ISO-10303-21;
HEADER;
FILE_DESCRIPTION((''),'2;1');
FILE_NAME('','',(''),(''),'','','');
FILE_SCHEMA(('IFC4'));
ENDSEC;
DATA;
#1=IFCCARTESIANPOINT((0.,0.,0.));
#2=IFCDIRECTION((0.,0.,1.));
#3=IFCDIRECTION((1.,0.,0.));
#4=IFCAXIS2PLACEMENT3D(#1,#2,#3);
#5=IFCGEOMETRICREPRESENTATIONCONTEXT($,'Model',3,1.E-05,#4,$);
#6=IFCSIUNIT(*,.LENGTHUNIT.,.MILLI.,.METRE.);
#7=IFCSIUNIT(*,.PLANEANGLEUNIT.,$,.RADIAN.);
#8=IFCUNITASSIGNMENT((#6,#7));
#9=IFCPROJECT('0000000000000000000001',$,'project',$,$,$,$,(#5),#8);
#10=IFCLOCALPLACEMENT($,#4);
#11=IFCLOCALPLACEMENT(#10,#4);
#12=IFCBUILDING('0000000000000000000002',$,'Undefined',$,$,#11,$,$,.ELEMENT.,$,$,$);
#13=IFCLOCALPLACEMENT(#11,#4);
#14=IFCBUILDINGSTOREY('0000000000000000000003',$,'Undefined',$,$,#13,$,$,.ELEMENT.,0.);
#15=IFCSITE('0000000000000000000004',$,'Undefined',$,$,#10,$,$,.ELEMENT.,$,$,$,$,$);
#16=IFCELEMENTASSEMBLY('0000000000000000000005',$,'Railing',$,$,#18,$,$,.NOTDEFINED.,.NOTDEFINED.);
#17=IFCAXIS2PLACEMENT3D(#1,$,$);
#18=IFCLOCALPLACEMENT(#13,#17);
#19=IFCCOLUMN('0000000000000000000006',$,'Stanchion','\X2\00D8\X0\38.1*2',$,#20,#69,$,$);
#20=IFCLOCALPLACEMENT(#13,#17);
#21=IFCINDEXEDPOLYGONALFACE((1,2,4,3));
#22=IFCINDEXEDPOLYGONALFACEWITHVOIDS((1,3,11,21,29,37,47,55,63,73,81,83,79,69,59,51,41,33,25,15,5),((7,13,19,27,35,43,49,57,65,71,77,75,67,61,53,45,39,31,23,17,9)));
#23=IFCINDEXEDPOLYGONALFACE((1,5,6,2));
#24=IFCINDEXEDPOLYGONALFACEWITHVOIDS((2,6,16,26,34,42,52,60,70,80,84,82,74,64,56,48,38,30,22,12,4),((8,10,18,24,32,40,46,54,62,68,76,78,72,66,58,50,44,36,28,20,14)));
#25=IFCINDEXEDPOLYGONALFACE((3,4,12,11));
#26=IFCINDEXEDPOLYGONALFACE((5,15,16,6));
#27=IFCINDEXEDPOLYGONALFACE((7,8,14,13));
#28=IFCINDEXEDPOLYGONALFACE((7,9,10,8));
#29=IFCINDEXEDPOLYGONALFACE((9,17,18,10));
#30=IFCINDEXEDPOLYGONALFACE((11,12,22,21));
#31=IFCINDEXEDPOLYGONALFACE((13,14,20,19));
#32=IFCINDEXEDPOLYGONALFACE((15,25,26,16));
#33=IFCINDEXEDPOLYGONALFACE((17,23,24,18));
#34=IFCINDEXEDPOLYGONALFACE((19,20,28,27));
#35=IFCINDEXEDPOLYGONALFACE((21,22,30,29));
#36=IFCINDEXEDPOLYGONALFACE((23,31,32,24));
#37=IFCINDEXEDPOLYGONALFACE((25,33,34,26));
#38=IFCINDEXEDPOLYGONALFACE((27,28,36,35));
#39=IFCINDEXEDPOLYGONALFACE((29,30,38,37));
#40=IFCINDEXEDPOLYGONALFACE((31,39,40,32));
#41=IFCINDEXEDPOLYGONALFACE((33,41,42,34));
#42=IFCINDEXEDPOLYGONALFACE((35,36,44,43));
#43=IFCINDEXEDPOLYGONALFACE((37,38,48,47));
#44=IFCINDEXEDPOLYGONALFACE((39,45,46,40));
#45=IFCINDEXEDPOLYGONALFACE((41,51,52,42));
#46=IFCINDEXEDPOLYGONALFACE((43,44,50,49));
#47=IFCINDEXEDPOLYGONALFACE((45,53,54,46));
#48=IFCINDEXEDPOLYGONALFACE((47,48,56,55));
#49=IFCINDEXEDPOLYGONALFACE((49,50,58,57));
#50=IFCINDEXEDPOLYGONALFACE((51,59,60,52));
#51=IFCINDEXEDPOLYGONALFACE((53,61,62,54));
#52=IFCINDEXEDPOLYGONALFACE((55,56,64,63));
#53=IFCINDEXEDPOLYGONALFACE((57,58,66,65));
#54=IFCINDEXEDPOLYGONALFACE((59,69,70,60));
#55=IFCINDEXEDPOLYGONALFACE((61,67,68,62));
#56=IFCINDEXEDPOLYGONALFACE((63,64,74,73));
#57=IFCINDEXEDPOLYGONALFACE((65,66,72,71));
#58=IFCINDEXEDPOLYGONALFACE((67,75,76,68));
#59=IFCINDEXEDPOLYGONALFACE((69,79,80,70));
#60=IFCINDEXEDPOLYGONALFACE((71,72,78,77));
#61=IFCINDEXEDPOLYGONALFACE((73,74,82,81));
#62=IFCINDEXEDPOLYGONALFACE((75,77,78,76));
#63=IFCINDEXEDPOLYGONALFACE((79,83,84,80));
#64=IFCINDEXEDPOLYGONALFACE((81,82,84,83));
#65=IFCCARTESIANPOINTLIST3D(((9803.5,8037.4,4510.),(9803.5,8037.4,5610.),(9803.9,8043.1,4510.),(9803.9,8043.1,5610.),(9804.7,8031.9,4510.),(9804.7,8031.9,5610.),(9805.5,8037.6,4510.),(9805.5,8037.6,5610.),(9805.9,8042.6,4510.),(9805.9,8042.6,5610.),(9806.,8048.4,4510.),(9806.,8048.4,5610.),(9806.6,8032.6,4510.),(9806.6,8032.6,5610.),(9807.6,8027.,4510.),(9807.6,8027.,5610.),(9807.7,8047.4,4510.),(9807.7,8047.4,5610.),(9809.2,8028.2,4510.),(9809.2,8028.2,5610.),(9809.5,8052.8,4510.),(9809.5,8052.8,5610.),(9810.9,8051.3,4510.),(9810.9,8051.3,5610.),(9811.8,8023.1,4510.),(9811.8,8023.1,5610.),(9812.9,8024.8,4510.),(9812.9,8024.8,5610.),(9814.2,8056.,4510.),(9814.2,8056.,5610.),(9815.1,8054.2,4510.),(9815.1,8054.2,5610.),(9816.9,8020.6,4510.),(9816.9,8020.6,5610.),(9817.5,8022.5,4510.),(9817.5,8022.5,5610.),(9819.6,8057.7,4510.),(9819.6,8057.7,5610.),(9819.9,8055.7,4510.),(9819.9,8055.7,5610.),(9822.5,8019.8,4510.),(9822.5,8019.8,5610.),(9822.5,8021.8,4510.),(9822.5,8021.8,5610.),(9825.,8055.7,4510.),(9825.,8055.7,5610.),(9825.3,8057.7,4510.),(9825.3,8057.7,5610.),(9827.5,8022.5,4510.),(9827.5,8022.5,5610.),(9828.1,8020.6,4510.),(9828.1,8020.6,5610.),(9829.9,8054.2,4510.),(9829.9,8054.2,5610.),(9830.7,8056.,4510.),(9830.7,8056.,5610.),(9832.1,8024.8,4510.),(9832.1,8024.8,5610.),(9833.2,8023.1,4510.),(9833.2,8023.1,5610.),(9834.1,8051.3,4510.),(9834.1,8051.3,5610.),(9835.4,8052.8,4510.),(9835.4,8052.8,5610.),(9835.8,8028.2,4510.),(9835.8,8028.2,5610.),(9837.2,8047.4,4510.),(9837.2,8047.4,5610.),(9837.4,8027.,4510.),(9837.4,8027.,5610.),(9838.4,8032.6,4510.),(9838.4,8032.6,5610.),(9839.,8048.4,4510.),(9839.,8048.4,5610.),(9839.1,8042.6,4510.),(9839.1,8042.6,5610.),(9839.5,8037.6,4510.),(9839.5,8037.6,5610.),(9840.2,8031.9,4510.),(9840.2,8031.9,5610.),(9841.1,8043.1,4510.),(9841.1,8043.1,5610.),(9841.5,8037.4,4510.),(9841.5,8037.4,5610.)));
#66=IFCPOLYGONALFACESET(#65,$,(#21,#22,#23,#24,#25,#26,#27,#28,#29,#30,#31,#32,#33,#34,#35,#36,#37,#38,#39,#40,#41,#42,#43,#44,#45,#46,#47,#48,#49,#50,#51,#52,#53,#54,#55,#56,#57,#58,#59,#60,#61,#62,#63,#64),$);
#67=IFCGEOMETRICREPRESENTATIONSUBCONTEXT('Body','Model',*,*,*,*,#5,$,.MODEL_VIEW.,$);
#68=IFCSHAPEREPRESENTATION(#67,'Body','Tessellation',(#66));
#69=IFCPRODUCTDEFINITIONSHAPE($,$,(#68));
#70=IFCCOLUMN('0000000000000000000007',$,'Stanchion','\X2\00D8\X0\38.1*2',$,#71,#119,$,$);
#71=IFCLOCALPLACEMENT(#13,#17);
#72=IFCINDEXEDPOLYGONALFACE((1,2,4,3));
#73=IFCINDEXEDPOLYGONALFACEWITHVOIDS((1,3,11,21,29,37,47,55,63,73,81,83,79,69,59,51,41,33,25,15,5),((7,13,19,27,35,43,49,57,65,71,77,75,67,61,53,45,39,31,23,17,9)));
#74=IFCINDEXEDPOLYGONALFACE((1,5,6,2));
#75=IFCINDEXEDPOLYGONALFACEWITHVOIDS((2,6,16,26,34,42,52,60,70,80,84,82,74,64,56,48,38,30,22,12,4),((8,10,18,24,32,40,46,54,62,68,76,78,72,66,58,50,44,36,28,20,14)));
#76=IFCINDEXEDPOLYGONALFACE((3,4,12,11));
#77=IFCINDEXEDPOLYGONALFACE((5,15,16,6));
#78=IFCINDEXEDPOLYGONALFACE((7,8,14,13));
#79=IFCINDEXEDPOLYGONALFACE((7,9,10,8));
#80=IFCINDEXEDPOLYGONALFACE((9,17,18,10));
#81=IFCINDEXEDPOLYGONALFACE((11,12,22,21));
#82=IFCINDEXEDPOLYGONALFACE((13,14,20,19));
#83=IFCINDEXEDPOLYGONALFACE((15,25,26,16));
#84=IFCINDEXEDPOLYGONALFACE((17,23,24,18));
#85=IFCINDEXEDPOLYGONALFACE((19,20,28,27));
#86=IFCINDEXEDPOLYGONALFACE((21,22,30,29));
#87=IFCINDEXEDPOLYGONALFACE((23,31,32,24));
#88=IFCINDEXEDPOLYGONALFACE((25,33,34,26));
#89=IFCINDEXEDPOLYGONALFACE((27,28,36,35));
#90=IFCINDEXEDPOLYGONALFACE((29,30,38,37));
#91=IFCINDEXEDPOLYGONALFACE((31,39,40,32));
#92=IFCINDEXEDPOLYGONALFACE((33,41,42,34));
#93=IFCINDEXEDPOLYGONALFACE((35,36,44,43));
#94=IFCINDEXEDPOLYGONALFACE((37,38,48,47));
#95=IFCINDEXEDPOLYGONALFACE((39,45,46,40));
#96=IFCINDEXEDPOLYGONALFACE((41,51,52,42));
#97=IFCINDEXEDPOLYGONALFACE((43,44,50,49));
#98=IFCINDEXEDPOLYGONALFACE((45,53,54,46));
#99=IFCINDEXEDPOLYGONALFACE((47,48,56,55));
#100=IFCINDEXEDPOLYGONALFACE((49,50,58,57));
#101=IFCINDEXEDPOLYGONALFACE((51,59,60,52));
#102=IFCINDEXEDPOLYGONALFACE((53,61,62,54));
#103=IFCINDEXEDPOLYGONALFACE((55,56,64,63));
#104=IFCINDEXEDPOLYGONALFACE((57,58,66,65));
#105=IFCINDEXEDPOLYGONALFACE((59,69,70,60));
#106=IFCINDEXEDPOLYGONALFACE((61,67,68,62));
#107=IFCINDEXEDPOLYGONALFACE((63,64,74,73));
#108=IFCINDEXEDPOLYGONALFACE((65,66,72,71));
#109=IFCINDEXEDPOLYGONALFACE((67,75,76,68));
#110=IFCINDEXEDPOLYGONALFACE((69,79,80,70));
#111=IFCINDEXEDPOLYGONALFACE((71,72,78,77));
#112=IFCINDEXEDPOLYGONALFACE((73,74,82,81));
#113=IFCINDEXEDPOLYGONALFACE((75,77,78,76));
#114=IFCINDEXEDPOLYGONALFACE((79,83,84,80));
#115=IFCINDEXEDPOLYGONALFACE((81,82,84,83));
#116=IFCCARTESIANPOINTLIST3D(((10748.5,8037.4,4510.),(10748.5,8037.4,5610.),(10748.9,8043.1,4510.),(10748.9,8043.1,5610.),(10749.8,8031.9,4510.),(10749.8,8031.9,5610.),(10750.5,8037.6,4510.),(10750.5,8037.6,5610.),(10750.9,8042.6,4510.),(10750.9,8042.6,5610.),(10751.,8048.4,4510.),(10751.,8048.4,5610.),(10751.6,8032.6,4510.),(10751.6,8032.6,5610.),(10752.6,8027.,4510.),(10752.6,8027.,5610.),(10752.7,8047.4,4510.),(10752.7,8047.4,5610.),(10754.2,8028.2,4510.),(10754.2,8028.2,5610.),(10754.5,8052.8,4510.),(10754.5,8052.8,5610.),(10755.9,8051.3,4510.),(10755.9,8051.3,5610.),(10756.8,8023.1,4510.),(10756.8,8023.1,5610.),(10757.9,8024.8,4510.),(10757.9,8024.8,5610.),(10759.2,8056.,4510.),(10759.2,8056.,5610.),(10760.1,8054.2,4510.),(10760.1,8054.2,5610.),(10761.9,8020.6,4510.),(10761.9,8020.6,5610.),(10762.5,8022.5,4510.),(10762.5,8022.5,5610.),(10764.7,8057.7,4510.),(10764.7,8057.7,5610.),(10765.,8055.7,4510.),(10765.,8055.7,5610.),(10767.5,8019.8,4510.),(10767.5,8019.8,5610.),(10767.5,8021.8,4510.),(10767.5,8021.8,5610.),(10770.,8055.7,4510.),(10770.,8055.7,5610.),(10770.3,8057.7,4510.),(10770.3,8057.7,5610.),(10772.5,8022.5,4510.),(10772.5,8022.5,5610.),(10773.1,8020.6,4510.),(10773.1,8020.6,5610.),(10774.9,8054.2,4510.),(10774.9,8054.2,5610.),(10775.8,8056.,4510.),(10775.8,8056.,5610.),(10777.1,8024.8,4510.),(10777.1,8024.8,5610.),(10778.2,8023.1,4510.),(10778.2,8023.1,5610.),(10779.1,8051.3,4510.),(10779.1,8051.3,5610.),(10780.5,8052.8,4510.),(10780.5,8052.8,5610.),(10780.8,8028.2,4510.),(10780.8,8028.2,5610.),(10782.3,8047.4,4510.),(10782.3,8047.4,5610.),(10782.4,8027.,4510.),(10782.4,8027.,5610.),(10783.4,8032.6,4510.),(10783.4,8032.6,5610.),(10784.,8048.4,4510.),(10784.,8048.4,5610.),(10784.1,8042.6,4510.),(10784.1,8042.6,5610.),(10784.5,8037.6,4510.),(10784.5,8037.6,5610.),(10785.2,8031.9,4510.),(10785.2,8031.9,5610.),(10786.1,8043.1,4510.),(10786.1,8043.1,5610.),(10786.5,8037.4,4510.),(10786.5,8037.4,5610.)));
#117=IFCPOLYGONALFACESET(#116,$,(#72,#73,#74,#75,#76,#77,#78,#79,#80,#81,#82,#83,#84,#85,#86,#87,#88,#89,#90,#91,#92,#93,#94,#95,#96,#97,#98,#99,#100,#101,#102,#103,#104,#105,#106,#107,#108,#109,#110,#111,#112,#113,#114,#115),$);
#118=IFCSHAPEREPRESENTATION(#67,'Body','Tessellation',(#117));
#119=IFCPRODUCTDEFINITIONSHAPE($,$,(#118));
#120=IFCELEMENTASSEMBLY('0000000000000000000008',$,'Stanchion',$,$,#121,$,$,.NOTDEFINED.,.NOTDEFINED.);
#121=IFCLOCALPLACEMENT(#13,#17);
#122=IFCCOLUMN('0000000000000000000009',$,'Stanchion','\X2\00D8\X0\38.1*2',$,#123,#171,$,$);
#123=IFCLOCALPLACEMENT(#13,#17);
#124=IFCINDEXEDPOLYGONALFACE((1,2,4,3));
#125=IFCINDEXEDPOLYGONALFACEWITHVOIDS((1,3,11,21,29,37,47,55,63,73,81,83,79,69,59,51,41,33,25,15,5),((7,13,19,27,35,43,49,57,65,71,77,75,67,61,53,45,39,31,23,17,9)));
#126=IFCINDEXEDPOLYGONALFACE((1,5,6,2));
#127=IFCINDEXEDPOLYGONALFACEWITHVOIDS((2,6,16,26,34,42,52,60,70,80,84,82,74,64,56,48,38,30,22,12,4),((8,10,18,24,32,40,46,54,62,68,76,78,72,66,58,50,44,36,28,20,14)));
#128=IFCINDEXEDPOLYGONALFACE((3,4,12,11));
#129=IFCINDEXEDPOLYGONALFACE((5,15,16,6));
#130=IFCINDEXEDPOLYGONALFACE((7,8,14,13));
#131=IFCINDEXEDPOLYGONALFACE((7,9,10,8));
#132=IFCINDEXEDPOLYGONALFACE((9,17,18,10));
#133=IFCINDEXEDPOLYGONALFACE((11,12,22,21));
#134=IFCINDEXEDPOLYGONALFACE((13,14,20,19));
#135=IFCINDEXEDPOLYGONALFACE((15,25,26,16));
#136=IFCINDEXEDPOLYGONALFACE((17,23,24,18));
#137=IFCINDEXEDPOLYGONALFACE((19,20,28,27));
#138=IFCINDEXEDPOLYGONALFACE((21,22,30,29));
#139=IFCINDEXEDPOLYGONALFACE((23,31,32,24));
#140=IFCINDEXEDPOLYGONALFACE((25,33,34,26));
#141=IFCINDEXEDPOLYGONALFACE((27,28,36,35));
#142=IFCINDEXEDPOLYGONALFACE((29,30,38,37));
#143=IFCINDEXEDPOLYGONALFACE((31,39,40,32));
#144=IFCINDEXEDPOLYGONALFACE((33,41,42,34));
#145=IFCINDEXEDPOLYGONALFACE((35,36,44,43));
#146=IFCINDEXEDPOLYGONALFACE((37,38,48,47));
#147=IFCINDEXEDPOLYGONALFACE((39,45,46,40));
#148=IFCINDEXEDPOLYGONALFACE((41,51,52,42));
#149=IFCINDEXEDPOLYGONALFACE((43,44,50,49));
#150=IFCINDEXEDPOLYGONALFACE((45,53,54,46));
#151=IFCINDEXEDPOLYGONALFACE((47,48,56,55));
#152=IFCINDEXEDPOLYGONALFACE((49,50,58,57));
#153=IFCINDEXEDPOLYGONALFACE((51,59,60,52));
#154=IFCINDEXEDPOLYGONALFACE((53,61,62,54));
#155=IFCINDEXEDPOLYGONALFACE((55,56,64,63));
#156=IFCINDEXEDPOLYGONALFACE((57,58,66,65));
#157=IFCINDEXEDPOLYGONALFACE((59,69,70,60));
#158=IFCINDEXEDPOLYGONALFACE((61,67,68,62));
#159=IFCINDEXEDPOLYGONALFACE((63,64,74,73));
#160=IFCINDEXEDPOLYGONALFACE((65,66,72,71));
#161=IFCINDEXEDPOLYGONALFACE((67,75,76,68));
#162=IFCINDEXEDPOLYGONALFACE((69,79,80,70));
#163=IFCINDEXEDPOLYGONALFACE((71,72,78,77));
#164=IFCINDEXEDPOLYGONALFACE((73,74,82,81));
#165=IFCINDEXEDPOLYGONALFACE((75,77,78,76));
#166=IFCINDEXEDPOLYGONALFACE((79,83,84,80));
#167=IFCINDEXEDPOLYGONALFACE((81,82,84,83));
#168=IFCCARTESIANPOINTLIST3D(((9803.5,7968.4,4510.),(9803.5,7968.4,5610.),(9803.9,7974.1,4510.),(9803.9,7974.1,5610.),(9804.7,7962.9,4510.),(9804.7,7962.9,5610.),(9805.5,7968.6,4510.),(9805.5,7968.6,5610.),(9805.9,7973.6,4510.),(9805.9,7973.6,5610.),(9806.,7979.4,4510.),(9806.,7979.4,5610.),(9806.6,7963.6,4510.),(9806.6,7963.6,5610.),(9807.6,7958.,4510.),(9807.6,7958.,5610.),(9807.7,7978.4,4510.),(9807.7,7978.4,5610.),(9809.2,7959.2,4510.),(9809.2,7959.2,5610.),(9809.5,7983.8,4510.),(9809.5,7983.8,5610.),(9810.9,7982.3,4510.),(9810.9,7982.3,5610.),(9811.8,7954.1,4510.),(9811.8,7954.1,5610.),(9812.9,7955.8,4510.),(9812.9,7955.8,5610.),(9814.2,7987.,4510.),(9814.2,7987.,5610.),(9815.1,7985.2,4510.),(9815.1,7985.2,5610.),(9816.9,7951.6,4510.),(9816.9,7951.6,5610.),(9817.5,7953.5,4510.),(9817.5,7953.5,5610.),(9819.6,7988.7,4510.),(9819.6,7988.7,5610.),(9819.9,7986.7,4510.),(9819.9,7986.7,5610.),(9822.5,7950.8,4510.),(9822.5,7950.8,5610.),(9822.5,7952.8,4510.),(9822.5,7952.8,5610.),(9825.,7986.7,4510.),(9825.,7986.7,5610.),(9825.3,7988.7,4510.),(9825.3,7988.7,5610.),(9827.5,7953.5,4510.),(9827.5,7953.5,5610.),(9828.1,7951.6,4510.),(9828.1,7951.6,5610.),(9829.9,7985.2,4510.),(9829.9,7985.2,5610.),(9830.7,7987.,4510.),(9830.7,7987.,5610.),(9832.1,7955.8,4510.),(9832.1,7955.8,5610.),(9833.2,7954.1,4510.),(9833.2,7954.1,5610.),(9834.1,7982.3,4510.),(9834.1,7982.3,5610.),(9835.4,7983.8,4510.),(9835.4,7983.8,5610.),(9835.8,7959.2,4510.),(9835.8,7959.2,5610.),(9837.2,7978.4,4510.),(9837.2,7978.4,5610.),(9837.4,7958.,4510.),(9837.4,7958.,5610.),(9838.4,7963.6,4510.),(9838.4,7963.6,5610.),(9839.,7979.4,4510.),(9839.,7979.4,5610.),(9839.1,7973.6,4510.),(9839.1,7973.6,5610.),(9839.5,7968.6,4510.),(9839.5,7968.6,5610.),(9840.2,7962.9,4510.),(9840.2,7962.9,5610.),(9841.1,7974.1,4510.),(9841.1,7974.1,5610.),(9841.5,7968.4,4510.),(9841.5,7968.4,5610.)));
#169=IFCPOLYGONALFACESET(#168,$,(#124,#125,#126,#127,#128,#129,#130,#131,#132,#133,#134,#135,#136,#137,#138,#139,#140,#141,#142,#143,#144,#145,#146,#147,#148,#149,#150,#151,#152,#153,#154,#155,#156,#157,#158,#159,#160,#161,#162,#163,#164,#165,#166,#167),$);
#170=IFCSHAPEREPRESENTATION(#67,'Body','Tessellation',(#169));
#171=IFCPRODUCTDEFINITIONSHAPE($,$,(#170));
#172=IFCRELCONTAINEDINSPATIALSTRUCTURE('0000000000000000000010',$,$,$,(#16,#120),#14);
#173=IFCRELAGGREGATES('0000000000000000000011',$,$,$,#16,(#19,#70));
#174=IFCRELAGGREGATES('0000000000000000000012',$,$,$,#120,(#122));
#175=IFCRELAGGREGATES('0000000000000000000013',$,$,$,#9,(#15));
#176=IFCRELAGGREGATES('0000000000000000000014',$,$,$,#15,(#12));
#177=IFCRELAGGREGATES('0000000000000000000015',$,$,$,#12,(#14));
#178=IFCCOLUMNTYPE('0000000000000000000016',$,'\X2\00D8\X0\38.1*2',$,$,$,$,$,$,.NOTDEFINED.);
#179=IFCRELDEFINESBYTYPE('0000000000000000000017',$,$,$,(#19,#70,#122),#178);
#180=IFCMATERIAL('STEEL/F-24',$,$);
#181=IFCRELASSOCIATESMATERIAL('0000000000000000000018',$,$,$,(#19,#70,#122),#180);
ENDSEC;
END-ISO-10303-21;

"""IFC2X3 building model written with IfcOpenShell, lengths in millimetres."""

from ifc_helpers import new_model, si_unit, frame, origin_with_axes, origin_2d_with_axis, place, context, subcontext, project, spatial, hollow_circle, extrude, material, type_object, element, aggregate, save


model = new_model("IFC2X3")

# Units and contexts
model_context = context("Model", 3, precision=1e-05, world=origin_with_axes())
body_context = subcontext(model_context, "Body", "Model", "MODEL_VIEW")
ifc_project = project(units=[si_unit("LENGTHUNIT", "METRE", prefix="MILLI"), si_unit("PLANEANGLEUNIT", "RADIAN")], contexts=[model_context])

# Site, building, storey
site_placement = place(None, origin_with_axes())
site = spatial("IfcSite", under=ifc_project, at=site_placement, Name="Undefined", CompositionType="ELEMENT")
building_placement = place(site_placement, origin_with_axes())
building = spatial("IfcBuilding", under=site, at=building_placement, Name="Undefined", CompositionType="ELEMENT")
storey_placement = place(building_placement, origin_with_axes())
storey = spatial("IfcBuildingStorey", under=building, at=storey_placement, Name="Undefined", CompositionType="ELEMENT", Elevation=0.0)

# Element assemblies, columns
assembly_1_placement = place(storey_placement, origin_with_axes())
assembly_1 = element("IfcElementAssembly", 1, at=assembly_1_placement, inside=storey, Name="Railing", AssemblyPlace="NOTDEFINED", PredefinedType="NOTDEFINED")
ifc_material_1 = material(Name="STEEL/F-24")
column_type = type_object("IfcColumnType", Name="Ø38.1*2", PredefinedType="NOTDEFINED")
column_1_placement = place(assembly_1_placement, frame((9822.5, 8038.8, 4510.0), z_axis=(0.0, 0.0, 1.0), x_axis=(-1.0, 0.0, 0.0)))
column_1 = element("IfcColumn", 2, at=column_1_placement, type_object=column_type, material=ifc_material_1, Name="Stanchion", Description="Ø38.1*2", context=body_context, shape_type="SweptSolid", body=[
    extrude(hollow_circle(Radius=19.1, WallThickness=2.0, at=origin_2d_with_axis()), frame((0.0, 0.0, 1100.0), z_axis=(0.0, 0.0, -1.0), x_axis=(0.0, 1.0, 0.0)), (0.0, 0.0, 1.0), 1100.0),
])
column_2_placement = place(assembly_1_placement, frame((10767.5, 8038.8, 4510.0), z_axis=(0.0, 0.0, 1.0), x_axis=(-1.0, 0.0, 0.0)))
column_2 = element("IfcColumn", 3, at=column_2_placement, type_object=column_type, material=ifc_material_1, Name="Stanchion", Description="Ø38.1*2", context=body_context, shape_type="SweptSolid", body=[
    extrude(hollow_circle(Radius=19.1, WallThickness=2.0, at=origin_2d_with_axis()), frame((0.0, 0.0, 1100.0), z_axis=(0.0, 0.0, -1.0), x_axis=(0.0, 1.0, 0.0)), (0.0, 0.0, 1.0), 1100.0),
])
assembly_2_placement = place(storey_placement, origin_with_axes())
assembly_2 = element("IfcElementAssembly", 4, at=assembly_2_placement, inside=storey, Name="Stanchion", AssemblyPlace="NOTDEFINED", PredefinedType="NOTDEFINED")
column_3_placement = place(assembly_2_placement, frame((9822.5, 7969.8, 4510.0), z_axis=(0.0, 0.0, 1.0), x_axis=(-1.0, 0.0, 0.0)))
column_3 = element("IfcColumn", 5, at=column_3_placement, type_object=column_type, material=ifc_material_1, Name="Stanchion", Description="Ø38.1*2", context=body_context, shape_type="SweptSolid", body=[
    extrude(hollow_circle(Radius=19.1, WallThickness=2.0, at=origin_2d_with_axis()), frame((0.0, 0.0, 1100.0), z_axis=(0.0, 0.0, -1.0), x_axis=(0.0, 1.0, 0.0)), (0.0, 0.0, 1.0), 1100.0),
])

aggregate(assembly_1, [column_1, column_2])
aggregate(assembly_2, [column_3])

save(model, "model.ifc")
